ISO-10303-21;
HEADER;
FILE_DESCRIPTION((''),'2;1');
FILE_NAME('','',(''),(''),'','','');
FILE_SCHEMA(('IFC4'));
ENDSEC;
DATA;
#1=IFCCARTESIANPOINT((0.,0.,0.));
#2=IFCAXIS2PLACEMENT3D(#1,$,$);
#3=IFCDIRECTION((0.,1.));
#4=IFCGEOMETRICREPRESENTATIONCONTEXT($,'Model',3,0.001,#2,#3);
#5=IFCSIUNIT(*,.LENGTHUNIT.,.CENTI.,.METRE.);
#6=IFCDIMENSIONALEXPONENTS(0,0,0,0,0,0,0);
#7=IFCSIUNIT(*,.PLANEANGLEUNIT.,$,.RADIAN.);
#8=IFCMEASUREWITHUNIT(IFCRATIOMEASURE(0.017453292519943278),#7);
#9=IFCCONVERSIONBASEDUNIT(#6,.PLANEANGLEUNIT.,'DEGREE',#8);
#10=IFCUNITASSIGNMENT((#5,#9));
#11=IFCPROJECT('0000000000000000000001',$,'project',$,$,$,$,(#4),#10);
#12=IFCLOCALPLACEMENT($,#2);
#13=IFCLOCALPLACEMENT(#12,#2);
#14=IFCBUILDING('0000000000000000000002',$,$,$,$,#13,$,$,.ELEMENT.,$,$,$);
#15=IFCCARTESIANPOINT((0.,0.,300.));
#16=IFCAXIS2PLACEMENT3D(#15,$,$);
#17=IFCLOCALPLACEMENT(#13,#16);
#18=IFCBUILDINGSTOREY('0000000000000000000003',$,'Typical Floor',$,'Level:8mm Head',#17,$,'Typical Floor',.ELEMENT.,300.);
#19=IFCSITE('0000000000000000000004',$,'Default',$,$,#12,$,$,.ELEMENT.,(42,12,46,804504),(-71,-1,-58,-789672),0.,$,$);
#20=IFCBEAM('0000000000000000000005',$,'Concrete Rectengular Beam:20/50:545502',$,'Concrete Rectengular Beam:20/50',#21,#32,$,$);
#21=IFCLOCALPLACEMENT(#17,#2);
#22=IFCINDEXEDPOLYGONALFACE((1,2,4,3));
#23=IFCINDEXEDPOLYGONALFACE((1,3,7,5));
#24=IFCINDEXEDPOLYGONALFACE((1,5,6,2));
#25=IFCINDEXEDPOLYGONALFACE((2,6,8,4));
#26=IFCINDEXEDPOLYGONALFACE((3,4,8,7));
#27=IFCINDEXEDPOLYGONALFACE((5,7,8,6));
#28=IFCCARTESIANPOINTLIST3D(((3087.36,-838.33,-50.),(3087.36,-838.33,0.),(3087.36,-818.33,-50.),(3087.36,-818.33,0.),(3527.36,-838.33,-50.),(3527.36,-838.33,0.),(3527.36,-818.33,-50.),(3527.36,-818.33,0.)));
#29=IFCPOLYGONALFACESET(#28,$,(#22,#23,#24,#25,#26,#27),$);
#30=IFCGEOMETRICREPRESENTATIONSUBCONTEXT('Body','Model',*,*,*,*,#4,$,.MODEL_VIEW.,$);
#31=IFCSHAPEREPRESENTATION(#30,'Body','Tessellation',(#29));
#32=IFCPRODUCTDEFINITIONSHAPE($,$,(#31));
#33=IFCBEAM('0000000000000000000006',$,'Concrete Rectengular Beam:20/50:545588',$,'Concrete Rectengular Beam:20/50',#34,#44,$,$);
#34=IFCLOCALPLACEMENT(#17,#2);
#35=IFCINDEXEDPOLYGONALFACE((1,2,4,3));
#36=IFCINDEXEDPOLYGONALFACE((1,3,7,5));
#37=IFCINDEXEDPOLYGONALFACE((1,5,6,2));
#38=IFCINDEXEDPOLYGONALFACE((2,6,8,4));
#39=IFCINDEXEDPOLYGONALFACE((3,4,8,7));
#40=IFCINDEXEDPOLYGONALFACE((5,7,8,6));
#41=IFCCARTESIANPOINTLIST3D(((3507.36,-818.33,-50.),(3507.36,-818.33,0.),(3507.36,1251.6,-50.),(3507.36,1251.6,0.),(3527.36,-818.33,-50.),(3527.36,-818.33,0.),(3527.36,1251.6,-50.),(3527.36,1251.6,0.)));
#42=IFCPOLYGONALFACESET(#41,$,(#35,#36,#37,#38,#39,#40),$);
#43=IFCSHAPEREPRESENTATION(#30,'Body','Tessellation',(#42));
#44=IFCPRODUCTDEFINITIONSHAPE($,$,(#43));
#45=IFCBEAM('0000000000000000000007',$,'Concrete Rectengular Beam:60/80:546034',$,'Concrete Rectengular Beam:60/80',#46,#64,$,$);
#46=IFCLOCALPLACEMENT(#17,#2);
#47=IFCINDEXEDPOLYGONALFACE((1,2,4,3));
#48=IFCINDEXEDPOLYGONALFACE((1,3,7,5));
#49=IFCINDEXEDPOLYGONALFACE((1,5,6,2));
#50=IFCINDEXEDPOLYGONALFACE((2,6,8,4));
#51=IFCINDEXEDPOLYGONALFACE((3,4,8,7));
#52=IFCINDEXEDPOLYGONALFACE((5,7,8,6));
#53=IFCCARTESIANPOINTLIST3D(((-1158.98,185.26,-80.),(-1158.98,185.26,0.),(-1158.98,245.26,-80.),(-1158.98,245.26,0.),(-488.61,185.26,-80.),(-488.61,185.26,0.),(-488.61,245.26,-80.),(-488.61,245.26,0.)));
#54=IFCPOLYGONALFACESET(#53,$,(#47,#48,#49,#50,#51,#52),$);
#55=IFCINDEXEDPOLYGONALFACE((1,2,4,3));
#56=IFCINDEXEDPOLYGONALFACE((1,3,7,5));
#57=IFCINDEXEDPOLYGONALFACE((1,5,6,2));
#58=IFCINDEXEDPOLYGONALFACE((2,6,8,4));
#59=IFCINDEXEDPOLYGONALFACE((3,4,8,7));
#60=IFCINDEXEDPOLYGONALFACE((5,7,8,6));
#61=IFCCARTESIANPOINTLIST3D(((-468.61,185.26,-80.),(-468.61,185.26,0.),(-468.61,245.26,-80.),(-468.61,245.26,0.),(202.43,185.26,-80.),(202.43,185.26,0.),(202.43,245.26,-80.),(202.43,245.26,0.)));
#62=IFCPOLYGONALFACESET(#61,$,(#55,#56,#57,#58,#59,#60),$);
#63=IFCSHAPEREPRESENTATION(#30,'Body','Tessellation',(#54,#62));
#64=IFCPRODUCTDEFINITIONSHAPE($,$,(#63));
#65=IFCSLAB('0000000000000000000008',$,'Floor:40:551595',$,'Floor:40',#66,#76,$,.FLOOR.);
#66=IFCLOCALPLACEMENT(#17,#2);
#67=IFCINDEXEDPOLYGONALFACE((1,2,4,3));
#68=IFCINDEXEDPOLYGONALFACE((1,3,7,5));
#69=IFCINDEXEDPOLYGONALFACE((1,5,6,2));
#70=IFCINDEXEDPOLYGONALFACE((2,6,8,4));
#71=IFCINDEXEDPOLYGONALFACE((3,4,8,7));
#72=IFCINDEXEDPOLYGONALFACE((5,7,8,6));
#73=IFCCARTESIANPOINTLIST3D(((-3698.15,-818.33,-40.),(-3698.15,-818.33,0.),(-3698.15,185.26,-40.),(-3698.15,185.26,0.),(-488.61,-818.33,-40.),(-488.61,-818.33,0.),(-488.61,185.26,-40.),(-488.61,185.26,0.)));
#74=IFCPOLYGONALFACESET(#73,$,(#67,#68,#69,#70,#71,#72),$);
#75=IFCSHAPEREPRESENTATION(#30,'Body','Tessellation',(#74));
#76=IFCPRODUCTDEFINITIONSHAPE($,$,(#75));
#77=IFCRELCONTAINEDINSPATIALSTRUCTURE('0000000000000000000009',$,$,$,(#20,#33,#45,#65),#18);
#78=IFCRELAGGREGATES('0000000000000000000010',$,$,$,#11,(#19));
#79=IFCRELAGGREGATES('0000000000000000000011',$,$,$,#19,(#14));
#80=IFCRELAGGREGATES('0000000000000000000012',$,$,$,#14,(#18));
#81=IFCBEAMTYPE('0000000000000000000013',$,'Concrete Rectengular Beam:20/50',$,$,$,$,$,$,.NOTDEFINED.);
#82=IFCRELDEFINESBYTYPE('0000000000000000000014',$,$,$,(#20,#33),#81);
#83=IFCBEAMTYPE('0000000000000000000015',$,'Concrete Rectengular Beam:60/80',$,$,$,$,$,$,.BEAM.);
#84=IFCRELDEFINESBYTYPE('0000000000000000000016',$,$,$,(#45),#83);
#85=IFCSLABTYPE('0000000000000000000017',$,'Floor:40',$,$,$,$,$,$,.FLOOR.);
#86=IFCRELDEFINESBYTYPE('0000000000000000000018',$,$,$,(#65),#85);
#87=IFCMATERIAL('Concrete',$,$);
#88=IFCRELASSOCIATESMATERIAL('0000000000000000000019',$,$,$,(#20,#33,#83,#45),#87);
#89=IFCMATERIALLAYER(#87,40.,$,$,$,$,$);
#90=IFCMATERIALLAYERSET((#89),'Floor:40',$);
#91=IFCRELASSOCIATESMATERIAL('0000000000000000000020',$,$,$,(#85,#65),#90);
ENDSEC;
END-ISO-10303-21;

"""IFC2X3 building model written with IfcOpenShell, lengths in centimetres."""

from ifc_helpers import new_model, entity, si_unit, converted_unit, direction, frame, frame_2d, origin, place, context, subcontext, project, spatial, rectangle, extrude, source, transform, mapped, material, layer, layer_set, layer_usage, type_object, type_shapes, element, save


model = new_model("IFC2X3")

# Units and contexts
model_context = context("Model", 3, precision=0.001, world=origin(), true_north=direction((0.0, 1.0)))
body_context = subcontext(model_context, "Body", "Model", "MODEL_VIEW")
ifc_project = project(units=[si_unit("LENGTHUNIT", "METRE", prefix="CENTI"), converted_unit("PLANEANGLEUNIT", "DEGREE", entity("IfcRatioMeasure", 0.017453292519943278), si_unit("PLANEANGLEUNIT", "RADIAN"), dimensions=[0, 0, 0, 0, 0, 0, 0])], contexts=[model_context])

# Site, building, storey
site_placement = place(None, origin())
site = spatial("IfcSite", under=ifc_project, at=site_placement, Name="Default", CompositionType="ELEMENT", RefLatitude=(42, 12, 46, 804504), RefLongitude=(-71, -1, -58, -789672), RefElevation=0.0)
building_placement = place(site_placement, origin())
building = spatial("IfcBuilding", under=site, at=building_placement, CompositionType="ELEMENT")
storey_placement = place(building_placement, frame((0.0, 0.0, 300.0)))
storey = spatial("IfcBuildingStorey", under=building, at=storey_placement, Name="Typical Floor", ObjectType="Level:8mm Head", LongName="Typical Floor", CompositionType="ELEMENT", Elevation=300.0)

# Beams
ifc_material = material(Name="Concrete")
beam_type_1 = type_object("IfcBeamType", Name="Concrete Rectengular Beam:20/50", PredefinedType="NOTDEFINED")
beam_1_placement = place(storey_placement, frame((3087.36, -828.33, 0.0)))
element("IfcBeam", 1, at=beam_1_placement, inside=storey, type_object=beam_type_1, material=ifc_material, Name="Concrete Rectengular Beam:20/50:545502", ObjectType="Concrete Rectengular Beam:20/50", context=body_context, shape_type="SweptSolid", body=[
    extrude(rectangle(XDim=50.0, YDim=20.0, at=frame_2d((0.0, 0.0), x_axis=(1.0, 0.0))), frame((0.0, 0.0, -25.0), z_axis=(1.0, 0.0, 0.0), x_axis=(0.0, 0.0, -1.0)), (0.0, 0.0, 1.0), 440.0),
])
beam_2_placement = place(storey_placement, frame((3517.36, -828.33, 0.0), z_axis=(0.0, 0.0, 1.0), x_axis=(0.0, 1.0, 0.0)))
element("IfcBeam", 2, at=beam_2_placement, inside=storey, type_object=beam_type_1, material=ifc_material, Name="Concrete Rectengular Beam:20/50:545588", ObjectType="Concrete Rectengular Beam:20/50", context=body_context, shape_type="SweptSolid", body=[
    extrude(rectangle(XDim=50.0, YDim=20.0, at=frame_2d((0.0, 0.0), x_axis=(1.0, 0.0))), frame((10.0, 0.0, -25.0), z_axis=(1.0, 0.0, 0.0), x_axis=(0.0, 0.0, -1.0)), (0.0, 0.0, 1.0), 2069.93),
])
beam_type_2 = type_object("IfcBeamType", Name="Concrete Rectengular Beam:60/80", PredefinedType="BEAM", material=ifc_material)
shared_shape = source(origin(), body_context, "Body", "SweptSolid", [
    extrude(rectangle(XDim=80.0, YDim=60.0, at=frame_2d((0.0, 0.0), x_axis=(1.0, 0.0))), frame((-488.61, 215.26, 260.0), z_axis=(-1.0, 0.0, 0.0), x_axis=(0.0, 0.0, -1.0)), (0.0, 0.0, 1.0), 670.36),
    extrude(rectangle(XDim=80.0, YDim=60.0, at=frame_2d((0.0, 0.0), x_axis=(1.0, 0.0))), frame((202.43, 215.26, 260.0), z_axis=(-1.0, 0.0, 0.0), x_axis=(0.0, 0.0, -1.0)), (0.0, 0.0, 1.0), 671.05),
])
type_shapes(beam_type_2, [shared_shape])
beam_3_placement = place(storey_placement, frame((0.0, 0.0, -300.0)))
element("IfcBeam", 3, at=beam_3_placement, inside=storey, type_object=beam_type_2, material=ifc_material, Name="Concrete Rectengular Beam:60/80:546034", ObjectType="Concrete Rectengular Beam:60/80", context=body_context, shape_type="MappedRepresentation", body=[
    mapped(shared_shape, transform((0.0, 0.0, 0.0), scale=1.0)),
])

# Slab
ifc_layer_1 = layer(ifc_material, 40.0)
ifc_layer_set_1 = layer_set([ifc_layer_1], Name="Floor:40")
ifc_layer_usage_1 = layer_usage(ifc_layer_set_1, "AXIS3", "POSITIVE", 0.0)
slab_type_1 = type_object("IfcSlabType", Name="Floor:40", PredefinedType="FLOOR", material=ifc_layer_set_1)
slab_1_placement = place(storey_placement, origin())
element("IfcSlab", 4, at=slab_1_placement, inside=storey, type_object=slab_type_1, material=ifc_layer_usage_1, Name="Floor:40:551595", ObjectType="Floor:40", PredefinedType="FLOOR", context=body_context, shape_type="SweptSolid", body=[
    extrude(rectangle(XDim=1003.59, YDim=3209.54, at=frame_2d((0.0, 0.0), x_axis=(1.0, 0.0))), frame((-2093.38, -316.54, 0.0), z_axis=(0.0, 0.0, -1.0), x_axis=(0.0, 1.0, 0.0)), (0.0, 0.0, 1.0), 40.0),
])

save(model, "model.ifc")
